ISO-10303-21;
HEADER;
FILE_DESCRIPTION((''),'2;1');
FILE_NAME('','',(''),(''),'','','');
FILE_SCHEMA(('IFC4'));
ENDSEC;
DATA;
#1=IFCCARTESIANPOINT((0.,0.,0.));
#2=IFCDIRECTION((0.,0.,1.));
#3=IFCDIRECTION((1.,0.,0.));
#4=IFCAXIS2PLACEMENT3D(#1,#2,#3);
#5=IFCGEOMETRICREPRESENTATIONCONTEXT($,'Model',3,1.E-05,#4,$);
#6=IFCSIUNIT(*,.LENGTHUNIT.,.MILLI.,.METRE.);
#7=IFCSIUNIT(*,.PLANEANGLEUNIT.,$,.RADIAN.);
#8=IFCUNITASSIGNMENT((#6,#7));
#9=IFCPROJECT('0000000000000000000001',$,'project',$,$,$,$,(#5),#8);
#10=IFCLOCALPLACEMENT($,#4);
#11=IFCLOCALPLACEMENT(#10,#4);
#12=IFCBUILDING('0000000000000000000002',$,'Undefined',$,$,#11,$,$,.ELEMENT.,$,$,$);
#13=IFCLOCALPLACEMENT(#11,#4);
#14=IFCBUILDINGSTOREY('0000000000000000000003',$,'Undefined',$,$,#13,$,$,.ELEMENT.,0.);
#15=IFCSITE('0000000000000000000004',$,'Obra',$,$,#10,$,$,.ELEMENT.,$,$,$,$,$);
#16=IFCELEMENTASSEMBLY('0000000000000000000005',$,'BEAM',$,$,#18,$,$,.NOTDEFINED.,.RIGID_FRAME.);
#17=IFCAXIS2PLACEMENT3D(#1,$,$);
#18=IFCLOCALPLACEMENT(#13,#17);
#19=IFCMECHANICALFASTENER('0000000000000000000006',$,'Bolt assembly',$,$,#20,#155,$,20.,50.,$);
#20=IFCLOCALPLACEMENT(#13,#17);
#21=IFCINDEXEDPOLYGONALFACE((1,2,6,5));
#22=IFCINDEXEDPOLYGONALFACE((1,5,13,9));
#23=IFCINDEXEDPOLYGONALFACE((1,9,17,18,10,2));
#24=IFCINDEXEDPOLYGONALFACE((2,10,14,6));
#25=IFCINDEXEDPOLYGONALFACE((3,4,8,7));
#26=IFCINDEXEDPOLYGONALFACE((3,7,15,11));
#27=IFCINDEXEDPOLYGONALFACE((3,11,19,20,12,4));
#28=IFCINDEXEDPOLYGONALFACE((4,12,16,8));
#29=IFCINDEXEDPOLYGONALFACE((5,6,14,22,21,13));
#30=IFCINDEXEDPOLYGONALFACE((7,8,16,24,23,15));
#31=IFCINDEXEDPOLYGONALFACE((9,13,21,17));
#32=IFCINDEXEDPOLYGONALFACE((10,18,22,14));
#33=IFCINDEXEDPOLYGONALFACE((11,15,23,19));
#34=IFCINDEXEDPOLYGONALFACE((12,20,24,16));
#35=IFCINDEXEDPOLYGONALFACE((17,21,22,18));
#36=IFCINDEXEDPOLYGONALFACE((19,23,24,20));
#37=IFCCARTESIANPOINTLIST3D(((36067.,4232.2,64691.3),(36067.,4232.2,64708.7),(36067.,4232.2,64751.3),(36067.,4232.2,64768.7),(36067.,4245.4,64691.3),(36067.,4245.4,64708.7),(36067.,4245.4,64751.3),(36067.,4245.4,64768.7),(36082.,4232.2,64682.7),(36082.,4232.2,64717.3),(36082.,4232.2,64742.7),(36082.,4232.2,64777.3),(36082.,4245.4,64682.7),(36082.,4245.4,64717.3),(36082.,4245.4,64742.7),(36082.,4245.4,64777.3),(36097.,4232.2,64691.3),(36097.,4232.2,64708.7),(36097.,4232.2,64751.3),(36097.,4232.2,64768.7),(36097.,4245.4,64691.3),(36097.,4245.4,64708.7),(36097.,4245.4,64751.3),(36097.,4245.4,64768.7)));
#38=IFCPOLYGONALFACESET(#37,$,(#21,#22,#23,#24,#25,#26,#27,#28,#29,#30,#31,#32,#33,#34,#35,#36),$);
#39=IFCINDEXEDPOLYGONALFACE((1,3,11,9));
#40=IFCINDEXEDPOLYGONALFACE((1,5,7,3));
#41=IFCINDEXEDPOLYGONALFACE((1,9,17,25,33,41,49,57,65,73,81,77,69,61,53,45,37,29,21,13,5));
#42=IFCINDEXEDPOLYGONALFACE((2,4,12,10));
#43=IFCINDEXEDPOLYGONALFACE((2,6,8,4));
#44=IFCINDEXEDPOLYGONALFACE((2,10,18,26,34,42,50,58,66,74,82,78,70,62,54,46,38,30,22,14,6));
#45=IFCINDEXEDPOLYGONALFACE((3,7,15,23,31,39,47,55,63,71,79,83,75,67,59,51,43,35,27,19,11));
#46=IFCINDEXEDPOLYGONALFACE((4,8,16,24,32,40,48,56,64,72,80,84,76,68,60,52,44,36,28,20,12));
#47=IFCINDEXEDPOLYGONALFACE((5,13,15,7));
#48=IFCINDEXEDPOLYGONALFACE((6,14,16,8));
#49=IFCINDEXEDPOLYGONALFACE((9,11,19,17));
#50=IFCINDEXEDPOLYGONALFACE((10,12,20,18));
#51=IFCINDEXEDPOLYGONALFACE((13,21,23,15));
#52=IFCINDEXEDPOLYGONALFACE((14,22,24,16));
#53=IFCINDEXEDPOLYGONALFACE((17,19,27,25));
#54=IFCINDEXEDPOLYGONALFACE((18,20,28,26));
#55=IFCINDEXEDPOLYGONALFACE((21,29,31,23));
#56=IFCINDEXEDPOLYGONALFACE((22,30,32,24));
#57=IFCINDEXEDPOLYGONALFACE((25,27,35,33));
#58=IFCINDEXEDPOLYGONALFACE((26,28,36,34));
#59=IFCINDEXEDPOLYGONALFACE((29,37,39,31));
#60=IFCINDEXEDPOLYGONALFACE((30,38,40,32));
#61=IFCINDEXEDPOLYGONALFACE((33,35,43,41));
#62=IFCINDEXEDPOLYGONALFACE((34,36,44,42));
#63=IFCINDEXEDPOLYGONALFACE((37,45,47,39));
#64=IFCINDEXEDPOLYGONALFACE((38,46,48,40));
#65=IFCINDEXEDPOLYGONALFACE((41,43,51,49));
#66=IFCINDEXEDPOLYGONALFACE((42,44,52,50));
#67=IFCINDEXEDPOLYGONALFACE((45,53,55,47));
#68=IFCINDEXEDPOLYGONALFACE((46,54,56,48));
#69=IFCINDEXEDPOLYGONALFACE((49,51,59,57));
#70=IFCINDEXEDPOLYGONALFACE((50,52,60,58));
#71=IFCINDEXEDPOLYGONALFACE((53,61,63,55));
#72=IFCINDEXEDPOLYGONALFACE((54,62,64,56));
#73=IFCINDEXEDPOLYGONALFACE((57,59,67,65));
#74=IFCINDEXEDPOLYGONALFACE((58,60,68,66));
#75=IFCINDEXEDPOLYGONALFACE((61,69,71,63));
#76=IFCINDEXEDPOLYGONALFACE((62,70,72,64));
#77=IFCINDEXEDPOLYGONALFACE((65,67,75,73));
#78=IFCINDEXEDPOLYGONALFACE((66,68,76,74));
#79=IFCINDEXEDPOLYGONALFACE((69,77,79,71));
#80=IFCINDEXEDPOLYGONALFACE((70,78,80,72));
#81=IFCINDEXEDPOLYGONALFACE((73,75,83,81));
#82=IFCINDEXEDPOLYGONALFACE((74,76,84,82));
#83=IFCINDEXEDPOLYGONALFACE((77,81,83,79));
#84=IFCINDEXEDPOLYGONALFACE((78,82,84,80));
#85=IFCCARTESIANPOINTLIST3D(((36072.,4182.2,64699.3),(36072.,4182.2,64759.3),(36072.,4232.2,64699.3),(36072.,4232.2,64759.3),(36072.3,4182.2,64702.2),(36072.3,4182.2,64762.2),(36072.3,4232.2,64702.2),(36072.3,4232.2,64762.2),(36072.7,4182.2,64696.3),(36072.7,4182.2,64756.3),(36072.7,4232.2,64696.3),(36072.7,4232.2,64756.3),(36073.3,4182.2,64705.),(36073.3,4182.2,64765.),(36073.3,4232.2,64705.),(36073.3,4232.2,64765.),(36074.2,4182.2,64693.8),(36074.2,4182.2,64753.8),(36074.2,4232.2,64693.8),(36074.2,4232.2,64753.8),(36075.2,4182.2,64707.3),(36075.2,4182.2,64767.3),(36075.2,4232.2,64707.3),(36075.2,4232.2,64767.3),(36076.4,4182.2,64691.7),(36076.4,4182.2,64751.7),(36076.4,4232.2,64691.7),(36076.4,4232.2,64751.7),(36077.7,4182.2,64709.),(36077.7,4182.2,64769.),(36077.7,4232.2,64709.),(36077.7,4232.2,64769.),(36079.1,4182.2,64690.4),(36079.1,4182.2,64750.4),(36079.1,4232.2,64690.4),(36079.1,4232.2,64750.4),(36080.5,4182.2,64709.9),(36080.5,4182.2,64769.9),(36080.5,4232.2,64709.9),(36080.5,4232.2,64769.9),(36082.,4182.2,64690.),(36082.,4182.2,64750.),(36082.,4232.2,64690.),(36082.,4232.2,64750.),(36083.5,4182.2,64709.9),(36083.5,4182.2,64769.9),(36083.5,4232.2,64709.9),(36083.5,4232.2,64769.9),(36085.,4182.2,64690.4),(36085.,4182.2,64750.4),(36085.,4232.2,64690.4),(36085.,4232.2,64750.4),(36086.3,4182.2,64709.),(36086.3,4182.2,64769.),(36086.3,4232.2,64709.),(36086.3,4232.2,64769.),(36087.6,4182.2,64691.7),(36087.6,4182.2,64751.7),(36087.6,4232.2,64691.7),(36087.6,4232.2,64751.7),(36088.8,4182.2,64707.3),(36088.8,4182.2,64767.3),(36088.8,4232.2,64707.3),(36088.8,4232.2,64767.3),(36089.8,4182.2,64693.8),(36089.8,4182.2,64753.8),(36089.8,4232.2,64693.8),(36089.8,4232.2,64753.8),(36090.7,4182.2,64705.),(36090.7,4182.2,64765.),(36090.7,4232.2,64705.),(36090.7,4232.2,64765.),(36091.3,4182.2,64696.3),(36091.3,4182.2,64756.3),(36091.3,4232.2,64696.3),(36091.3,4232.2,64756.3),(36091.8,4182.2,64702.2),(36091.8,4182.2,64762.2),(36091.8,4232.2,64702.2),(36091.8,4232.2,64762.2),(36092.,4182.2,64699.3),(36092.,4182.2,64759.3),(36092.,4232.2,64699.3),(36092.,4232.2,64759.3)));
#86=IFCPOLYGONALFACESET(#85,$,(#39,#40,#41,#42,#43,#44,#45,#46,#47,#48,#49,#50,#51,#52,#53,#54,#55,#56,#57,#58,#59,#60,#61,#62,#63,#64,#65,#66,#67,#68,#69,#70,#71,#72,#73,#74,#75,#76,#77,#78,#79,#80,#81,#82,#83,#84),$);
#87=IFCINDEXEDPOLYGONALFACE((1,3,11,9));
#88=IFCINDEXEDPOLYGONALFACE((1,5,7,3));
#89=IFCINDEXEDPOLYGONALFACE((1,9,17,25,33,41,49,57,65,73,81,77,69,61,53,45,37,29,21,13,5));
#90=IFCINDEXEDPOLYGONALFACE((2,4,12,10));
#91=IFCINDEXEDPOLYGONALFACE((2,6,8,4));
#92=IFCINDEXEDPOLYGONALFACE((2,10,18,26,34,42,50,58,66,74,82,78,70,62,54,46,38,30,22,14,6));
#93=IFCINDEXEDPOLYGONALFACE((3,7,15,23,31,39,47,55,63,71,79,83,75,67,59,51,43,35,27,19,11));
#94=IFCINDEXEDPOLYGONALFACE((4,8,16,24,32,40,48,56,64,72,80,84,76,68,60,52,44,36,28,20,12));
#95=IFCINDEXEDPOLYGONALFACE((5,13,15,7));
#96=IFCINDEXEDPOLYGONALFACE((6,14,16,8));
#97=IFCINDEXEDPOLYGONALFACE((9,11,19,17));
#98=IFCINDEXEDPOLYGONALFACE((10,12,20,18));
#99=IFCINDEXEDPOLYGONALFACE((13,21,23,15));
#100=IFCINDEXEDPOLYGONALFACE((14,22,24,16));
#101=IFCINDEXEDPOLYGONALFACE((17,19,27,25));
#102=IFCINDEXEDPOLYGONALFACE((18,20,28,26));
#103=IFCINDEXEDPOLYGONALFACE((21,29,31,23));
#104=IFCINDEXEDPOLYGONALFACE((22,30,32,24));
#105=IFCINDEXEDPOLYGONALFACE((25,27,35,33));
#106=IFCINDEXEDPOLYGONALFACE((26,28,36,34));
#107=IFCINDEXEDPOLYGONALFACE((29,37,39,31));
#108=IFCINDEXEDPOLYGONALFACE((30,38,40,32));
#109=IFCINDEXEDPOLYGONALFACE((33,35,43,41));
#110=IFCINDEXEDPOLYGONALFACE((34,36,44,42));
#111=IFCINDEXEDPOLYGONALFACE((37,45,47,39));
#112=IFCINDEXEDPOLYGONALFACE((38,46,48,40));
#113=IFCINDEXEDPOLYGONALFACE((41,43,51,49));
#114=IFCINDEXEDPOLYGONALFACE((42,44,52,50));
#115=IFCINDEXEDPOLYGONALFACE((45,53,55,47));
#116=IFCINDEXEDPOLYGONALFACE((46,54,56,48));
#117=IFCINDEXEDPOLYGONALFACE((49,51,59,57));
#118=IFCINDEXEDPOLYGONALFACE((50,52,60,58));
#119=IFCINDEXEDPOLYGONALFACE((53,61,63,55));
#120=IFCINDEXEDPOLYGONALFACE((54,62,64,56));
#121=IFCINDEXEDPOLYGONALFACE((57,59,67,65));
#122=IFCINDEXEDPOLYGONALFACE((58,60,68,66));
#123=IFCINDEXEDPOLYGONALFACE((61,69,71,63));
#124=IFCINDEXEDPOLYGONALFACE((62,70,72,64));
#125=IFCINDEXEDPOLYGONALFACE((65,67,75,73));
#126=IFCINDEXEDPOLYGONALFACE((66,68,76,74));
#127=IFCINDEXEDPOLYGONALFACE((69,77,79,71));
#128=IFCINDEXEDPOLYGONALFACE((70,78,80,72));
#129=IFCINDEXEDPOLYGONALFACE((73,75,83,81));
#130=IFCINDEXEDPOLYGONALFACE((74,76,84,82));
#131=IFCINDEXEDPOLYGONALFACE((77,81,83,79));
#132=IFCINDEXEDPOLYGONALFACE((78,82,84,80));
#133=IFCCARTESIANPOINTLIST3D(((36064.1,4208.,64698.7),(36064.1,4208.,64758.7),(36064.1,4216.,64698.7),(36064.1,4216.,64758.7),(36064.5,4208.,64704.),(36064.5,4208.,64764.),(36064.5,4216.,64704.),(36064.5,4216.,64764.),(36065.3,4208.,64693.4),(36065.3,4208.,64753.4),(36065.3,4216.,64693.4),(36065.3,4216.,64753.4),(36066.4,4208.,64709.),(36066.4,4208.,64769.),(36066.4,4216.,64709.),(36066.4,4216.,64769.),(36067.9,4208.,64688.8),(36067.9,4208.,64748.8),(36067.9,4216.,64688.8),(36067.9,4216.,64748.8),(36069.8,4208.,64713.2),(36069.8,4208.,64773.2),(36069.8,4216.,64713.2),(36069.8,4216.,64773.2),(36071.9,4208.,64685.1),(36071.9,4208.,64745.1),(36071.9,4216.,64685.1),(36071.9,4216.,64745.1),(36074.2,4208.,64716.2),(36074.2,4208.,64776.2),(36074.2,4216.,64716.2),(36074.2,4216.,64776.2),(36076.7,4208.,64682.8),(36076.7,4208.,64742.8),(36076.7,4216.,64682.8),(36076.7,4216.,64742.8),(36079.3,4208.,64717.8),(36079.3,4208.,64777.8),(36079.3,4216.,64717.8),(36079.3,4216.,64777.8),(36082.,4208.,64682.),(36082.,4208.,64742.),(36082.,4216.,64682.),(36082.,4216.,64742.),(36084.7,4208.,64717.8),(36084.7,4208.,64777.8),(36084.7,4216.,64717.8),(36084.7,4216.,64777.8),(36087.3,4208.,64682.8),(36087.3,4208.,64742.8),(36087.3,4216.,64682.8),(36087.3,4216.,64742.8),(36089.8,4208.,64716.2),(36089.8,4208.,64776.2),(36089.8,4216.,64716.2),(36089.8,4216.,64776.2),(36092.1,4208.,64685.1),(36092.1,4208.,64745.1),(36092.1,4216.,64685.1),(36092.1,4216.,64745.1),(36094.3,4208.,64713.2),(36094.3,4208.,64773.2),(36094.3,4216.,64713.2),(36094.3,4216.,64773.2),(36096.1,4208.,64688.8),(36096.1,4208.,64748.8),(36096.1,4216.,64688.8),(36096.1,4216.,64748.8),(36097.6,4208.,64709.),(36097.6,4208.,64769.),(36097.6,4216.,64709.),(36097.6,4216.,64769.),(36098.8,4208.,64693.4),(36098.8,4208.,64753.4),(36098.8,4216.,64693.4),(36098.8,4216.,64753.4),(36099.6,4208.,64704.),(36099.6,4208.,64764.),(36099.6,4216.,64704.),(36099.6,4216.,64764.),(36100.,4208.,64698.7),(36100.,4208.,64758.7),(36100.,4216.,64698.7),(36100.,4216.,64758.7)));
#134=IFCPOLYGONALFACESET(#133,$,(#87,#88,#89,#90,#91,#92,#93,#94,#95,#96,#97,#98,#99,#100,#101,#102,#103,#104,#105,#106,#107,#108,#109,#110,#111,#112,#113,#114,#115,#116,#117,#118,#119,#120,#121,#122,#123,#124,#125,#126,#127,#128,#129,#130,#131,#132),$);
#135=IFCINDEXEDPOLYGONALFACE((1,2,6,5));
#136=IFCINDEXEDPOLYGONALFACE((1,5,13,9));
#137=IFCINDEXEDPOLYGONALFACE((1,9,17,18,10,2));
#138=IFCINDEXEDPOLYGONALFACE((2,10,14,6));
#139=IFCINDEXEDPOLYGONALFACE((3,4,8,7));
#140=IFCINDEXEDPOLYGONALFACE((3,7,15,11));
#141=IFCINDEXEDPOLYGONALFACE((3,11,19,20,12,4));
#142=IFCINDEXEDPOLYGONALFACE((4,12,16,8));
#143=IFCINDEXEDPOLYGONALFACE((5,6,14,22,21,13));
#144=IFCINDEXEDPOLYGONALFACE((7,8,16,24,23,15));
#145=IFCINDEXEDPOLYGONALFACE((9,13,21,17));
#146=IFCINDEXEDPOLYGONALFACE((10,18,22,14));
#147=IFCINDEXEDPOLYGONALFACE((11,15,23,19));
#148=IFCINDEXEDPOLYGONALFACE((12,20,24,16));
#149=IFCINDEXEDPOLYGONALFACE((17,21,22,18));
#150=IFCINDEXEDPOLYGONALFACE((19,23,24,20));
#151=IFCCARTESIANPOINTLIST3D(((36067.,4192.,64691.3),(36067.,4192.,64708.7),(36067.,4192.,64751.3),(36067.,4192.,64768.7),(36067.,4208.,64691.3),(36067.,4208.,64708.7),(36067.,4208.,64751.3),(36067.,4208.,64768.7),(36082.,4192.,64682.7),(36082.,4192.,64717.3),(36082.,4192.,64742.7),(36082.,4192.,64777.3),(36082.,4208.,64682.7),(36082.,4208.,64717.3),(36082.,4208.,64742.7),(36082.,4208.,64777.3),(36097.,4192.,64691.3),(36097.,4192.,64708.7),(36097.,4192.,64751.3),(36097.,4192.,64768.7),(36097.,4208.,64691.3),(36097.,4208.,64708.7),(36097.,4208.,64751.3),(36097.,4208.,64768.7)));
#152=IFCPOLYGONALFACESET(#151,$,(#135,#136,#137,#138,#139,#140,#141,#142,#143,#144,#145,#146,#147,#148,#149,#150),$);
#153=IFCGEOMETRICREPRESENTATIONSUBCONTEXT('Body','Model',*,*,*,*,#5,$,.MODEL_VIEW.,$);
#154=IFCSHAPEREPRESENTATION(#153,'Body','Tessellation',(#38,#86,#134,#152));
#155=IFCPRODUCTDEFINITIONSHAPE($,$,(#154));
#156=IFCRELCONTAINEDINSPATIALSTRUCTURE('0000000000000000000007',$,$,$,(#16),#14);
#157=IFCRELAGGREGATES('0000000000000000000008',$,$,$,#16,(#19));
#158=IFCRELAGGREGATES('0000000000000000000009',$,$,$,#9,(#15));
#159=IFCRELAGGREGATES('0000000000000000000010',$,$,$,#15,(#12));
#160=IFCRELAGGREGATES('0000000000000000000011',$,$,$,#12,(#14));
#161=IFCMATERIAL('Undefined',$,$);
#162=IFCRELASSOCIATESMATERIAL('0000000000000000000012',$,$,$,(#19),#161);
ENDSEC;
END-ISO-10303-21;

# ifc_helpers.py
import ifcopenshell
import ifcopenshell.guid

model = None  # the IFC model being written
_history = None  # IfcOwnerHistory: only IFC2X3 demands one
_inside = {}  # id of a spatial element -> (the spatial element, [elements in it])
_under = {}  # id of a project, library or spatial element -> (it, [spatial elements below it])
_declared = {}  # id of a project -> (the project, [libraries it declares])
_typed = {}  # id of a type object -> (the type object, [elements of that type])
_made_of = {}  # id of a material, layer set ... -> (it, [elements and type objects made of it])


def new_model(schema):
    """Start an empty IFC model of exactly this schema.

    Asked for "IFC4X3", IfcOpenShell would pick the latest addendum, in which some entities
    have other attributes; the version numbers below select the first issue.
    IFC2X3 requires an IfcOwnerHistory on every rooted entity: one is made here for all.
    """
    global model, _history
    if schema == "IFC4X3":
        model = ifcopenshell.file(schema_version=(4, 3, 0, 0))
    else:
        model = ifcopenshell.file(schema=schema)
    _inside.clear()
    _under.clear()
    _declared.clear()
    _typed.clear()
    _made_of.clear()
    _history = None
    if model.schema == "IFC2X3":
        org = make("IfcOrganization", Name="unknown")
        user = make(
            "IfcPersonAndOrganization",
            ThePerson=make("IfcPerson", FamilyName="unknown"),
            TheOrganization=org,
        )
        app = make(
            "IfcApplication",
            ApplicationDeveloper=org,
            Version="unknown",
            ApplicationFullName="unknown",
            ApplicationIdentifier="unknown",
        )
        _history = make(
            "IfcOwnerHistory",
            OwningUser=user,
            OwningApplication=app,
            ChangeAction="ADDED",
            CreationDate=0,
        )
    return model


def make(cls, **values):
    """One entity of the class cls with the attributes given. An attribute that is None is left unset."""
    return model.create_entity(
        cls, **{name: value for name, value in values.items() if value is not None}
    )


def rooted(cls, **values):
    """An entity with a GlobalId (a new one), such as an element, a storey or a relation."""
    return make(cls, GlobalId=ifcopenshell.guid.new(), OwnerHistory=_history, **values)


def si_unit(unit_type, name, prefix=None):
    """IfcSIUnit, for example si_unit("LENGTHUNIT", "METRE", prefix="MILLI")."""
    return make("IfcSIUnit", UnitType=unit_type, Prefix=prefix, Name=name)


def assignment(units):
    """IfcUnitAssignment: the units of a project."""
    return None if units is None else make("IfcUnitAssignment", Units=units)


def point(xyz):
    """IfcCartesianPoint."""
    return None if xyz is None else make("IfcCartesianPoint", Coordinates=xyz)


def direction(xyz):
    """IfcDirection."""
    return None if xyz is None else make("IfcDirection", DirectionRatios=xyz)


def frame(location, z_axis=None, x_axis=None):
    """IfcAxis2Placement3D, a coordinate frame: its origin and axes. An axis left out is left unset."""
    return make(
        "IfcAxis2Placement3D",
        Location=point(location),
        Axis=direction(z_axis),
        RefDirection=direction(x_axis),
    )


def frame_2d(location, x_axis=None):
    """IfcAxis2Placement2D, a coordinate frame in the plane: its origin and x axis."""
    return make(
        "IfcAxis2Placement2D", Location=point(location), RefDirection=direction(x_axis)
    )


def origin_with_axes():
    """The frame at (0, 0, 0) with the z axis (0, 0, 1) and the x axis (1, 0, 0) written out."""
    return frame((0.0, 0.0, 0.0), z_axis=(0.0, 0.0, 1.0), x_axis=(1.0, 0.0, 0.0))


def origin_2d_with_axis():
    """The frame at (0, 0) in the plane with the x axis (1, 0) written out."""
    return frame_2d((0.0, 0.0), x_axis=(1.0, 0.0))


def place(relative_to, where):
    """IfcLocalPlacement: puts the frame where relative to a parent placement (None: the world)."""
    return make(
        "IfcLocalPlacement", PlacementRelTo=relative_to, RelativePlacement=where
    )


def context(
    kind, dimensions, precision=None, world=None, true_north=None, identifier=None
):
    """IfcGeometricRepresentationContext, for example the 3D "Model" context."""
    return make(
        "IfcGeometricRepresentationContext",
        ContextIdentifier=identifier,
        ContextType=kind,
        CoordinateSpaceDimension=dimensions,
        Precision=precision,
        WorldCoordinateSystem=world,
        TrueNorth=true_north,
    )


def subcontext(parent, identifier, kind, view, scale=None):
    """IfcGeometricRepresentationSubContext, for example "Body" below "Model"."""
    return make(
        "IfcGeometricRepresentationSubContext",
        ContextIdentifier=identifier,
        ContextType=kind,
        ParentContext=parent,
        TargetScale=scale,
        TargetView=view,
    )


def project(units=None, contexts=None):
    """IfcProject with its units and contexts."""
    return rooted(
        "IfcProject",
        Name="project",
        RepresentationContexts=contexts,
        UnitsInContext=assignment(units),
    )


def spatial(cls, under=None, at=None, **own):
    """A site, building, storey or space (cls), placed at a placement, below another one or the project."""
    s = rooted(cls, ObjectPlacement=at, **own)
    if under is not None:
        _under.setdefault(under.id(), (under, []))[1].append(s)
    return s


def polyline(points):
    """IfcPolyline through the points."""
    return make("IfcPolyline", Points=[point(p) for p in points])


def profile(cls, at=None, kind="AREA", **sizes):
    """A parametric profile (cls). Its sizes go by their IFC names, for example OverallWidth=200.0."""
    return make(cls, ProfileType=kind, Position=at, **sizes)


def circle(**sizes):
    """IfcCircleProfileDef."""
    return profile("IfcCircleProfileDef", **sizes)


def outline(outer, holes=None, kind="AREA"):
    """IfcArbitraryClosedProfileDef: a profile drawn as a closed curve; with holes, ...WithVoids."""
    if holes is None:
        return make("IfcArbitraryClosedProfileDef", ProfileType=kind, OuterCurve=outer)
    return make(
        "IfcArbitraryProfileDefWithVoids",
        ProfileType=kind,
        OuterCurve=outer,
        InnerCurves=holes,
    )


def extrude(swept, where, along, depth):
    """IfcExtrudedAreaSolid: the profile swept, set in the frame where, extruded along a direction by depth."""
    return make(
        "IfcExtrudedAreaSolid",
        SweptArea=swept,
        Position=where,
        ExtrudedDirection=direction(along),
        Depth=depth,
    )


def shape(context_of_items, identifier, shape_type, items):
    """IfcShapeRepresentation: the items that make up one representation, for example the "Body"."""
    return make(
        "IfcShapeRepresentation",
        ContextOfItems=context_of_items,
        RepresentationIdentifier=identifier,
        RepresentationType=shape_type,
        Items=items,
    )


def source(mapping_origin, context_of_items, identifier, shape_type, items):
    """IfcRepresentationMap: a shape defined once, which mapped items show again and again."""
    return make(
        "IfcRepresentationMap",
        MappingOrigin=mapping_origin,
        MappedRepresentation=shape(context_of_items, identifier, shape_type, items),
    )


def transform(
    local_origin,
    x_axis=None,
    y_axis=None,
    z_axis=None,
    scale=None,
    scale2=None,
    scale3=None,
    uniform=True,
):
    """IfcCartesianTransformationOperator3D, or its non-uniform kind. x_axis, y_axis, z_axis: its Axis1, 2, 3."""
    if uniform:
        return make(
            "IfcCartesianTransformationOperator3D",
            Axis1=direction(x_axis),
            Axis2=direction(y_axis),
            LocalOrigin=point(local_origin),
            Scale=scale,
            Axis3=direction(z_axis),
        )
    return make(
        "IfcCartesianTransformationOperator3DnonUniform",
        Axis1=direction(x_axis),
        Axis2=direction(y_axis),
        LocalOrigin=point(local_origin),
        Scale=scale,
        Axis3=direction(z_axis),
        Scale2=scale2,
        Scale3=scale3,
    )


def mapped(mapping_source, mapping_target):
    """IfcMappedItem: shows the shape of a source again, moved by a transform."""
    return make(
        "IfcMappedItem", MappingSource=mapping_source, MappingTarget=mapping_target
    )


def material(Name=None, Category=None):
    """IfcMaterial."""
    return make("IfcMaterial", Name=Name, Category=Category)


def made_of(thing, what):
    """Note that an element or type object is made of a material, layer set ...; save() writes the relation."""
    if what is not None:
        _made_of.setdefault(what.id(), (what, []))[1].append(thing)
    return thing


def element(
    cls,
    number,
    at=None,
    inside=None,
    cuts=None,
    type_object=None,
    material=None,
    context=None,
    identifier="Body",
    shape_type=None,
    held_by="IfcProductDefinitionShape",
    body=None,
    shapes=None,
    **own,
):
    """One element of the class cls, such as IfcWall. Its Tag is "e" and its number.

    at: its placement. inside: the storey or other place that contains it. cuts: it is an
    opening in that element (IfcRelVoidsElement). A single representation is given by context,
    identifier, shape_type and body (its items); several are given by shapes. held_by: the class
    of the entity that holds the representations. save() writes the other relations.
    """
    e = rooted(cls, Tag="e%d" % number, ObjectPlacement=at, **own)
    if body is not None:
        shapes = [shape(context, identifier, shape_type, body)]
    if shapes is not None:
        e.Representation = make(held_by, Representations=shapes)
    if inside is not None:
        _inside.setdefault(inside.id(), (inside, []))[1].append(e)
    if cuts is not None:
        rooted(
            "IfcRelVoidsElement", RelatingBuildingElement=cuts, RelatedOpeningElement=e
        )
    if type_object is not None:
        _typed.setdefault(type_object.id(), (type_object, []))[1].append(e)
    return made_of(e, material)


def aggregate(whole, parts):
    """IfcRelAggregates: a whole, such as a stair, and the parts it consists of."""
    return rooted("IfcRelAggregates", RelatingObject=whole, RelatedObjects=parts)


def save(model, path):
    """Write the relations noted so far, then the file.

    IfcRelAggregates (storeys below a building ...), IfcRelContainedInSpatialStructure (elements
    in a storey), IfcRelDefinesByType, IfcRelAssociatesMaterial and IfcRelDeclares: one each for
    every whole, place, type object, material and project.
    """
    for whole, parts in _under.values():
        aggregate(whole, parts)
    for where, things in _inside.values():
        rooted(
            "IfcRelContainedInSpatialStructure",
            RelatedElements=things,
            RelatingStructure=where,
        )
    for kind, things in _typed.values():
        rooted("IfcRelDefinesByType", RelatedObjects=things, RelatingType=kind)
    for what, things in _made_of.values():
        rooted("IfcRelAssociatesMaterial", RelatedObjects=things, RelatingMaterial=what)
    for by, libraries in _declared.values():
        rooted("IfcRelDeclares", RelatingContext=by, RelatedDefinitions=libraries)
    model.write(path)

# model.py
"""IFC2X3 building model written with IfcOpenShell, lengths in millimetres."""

from ifc_helpers import new_model, si_unit, frame, origin_with_axes, origin_2d_with_axis, place, context, subcontext, project, spatial, polyline, circle, outline, extrude, source, transform, mapped, material, element, aggregate, save


model = new_model("IFC2X3")

# Units and contexts
model_context = context("Model", 3, precision=1e-05, world=origin_with_axes())
body_context = subcontext(model_context, "Body", "Model", "MODEL_VIEW")
ifc_project = project(units=[si_unit("LENGTHUNIT", "METRE", prefix="MILLI"), si_unit("PLANEANGLEUNIT", "RADIAN")], contexts=[model_context])

# Site, building, storey
site_placement = place(None, origin_with_axes())
site = spatial("IfcSite", under=ifc_project, at=site_placement, Name="Obra", CompositionType="ELEMENT")
building_placement = place(site_placement, origin_with_axes())
building = spatial("IfcBuilding", under=site, at=building_placement, Name="Undefined", CompositionType="ELEMENT")
storey_placement = place(building_placement, origin_with_axes())
storey = spatial("IfcBuildingStorey", under=building, at=storey_placement, Name="Undefined", CompositionType="ELEMENT", Elevation=0.0)

# Shared definitions
ifc_material = material(Name="Undefined")

# Element assembly, mechanical fastener
shared_shape_1 = source(origin_with_axes(), body_context, "Body", "SweptSolid", [
    extrude(outline(polyline([(17.3, 0.0), (8.7, 15.0), (-8.7, 15.0), (-17.3, 0.0), (-8.7, -15.0), (8.7, -15.0), (17.3, 0.0)])), frame((0.0, -26.3, 0.0), z_axis=(0.0, 1.0, 0.0), x_axis=(1.0, 0.0, 0.0)), (0.0, 0.0, 1.0), 13.2),
    extrude(circle(Radius=10.0, at=origin_2d_with_axis()), frame((0.0, -13.1, 0.0), z_axis=(0.0, 1.0, 0.0), x_axis=(1.0, 0.0, 0.0)), (0.0, 0.0, 1.0), 50.0),
    extrude(circle(Radius=18.0, at=origin_2d_with_axis()), frame((0.0, 3.1, 0.0), z_axis=(0.0, 1.0, 0.0), x_axis=(1.0, 0.0, 0.0)), (0.0, 0.0, 1.0), 8.0),
    extrude(outline(polyline([(17.3, 0.0), (8.7, 15.0), (-8.7, 15.0), (-17.3, 0.0), (-8.7, -15.0), (8.7, -15.0), (17.3, 0.0)])), frame((0.0, 11.1, 0.0), z_axis=(0.0, 1.0, 0.0), x_axis=(1.0, 0.0, 0.0)), (0.0, 0.0, 1.0), 16.0),
])
assembly_1_placement = place(storey_placement, origin_with_axes())
assembly_1 = element("IfcElementAssembly", 1, at=assembly_1_placement, inside=storey, Name="BEAM", AssemblyPlace="NOTDEFINED", PredefinedType="RIGID_FRAME")
mechanical_fastener_1_placement = place(assembly_1_placement, frame((36122.0, 4219.1, 64850.0), z_axis=(-1.0, 0.0, 0.0), x_axis=(0.0, 0.0, -1.0)))
mechanical_fastener_1 = element("IfcMechanicalFastener", 2, at=mechanical_fastener_1_placement, material=ifc_material, Name="Bolt assembly", NominalDiameter=20.0, NominalLength=50.0, context=body_context, shape_type="MappedRepresentation", body=[
    mapped(shared_shape_1, transform((90.0, 0.0, 40.0))),
    mapped(shared_shape_1, transform((150.0, 0.0, 40.0))),
])

aggregate(assembly_1, [mechanical_fastener_1])

save(model, "model.ifc")
